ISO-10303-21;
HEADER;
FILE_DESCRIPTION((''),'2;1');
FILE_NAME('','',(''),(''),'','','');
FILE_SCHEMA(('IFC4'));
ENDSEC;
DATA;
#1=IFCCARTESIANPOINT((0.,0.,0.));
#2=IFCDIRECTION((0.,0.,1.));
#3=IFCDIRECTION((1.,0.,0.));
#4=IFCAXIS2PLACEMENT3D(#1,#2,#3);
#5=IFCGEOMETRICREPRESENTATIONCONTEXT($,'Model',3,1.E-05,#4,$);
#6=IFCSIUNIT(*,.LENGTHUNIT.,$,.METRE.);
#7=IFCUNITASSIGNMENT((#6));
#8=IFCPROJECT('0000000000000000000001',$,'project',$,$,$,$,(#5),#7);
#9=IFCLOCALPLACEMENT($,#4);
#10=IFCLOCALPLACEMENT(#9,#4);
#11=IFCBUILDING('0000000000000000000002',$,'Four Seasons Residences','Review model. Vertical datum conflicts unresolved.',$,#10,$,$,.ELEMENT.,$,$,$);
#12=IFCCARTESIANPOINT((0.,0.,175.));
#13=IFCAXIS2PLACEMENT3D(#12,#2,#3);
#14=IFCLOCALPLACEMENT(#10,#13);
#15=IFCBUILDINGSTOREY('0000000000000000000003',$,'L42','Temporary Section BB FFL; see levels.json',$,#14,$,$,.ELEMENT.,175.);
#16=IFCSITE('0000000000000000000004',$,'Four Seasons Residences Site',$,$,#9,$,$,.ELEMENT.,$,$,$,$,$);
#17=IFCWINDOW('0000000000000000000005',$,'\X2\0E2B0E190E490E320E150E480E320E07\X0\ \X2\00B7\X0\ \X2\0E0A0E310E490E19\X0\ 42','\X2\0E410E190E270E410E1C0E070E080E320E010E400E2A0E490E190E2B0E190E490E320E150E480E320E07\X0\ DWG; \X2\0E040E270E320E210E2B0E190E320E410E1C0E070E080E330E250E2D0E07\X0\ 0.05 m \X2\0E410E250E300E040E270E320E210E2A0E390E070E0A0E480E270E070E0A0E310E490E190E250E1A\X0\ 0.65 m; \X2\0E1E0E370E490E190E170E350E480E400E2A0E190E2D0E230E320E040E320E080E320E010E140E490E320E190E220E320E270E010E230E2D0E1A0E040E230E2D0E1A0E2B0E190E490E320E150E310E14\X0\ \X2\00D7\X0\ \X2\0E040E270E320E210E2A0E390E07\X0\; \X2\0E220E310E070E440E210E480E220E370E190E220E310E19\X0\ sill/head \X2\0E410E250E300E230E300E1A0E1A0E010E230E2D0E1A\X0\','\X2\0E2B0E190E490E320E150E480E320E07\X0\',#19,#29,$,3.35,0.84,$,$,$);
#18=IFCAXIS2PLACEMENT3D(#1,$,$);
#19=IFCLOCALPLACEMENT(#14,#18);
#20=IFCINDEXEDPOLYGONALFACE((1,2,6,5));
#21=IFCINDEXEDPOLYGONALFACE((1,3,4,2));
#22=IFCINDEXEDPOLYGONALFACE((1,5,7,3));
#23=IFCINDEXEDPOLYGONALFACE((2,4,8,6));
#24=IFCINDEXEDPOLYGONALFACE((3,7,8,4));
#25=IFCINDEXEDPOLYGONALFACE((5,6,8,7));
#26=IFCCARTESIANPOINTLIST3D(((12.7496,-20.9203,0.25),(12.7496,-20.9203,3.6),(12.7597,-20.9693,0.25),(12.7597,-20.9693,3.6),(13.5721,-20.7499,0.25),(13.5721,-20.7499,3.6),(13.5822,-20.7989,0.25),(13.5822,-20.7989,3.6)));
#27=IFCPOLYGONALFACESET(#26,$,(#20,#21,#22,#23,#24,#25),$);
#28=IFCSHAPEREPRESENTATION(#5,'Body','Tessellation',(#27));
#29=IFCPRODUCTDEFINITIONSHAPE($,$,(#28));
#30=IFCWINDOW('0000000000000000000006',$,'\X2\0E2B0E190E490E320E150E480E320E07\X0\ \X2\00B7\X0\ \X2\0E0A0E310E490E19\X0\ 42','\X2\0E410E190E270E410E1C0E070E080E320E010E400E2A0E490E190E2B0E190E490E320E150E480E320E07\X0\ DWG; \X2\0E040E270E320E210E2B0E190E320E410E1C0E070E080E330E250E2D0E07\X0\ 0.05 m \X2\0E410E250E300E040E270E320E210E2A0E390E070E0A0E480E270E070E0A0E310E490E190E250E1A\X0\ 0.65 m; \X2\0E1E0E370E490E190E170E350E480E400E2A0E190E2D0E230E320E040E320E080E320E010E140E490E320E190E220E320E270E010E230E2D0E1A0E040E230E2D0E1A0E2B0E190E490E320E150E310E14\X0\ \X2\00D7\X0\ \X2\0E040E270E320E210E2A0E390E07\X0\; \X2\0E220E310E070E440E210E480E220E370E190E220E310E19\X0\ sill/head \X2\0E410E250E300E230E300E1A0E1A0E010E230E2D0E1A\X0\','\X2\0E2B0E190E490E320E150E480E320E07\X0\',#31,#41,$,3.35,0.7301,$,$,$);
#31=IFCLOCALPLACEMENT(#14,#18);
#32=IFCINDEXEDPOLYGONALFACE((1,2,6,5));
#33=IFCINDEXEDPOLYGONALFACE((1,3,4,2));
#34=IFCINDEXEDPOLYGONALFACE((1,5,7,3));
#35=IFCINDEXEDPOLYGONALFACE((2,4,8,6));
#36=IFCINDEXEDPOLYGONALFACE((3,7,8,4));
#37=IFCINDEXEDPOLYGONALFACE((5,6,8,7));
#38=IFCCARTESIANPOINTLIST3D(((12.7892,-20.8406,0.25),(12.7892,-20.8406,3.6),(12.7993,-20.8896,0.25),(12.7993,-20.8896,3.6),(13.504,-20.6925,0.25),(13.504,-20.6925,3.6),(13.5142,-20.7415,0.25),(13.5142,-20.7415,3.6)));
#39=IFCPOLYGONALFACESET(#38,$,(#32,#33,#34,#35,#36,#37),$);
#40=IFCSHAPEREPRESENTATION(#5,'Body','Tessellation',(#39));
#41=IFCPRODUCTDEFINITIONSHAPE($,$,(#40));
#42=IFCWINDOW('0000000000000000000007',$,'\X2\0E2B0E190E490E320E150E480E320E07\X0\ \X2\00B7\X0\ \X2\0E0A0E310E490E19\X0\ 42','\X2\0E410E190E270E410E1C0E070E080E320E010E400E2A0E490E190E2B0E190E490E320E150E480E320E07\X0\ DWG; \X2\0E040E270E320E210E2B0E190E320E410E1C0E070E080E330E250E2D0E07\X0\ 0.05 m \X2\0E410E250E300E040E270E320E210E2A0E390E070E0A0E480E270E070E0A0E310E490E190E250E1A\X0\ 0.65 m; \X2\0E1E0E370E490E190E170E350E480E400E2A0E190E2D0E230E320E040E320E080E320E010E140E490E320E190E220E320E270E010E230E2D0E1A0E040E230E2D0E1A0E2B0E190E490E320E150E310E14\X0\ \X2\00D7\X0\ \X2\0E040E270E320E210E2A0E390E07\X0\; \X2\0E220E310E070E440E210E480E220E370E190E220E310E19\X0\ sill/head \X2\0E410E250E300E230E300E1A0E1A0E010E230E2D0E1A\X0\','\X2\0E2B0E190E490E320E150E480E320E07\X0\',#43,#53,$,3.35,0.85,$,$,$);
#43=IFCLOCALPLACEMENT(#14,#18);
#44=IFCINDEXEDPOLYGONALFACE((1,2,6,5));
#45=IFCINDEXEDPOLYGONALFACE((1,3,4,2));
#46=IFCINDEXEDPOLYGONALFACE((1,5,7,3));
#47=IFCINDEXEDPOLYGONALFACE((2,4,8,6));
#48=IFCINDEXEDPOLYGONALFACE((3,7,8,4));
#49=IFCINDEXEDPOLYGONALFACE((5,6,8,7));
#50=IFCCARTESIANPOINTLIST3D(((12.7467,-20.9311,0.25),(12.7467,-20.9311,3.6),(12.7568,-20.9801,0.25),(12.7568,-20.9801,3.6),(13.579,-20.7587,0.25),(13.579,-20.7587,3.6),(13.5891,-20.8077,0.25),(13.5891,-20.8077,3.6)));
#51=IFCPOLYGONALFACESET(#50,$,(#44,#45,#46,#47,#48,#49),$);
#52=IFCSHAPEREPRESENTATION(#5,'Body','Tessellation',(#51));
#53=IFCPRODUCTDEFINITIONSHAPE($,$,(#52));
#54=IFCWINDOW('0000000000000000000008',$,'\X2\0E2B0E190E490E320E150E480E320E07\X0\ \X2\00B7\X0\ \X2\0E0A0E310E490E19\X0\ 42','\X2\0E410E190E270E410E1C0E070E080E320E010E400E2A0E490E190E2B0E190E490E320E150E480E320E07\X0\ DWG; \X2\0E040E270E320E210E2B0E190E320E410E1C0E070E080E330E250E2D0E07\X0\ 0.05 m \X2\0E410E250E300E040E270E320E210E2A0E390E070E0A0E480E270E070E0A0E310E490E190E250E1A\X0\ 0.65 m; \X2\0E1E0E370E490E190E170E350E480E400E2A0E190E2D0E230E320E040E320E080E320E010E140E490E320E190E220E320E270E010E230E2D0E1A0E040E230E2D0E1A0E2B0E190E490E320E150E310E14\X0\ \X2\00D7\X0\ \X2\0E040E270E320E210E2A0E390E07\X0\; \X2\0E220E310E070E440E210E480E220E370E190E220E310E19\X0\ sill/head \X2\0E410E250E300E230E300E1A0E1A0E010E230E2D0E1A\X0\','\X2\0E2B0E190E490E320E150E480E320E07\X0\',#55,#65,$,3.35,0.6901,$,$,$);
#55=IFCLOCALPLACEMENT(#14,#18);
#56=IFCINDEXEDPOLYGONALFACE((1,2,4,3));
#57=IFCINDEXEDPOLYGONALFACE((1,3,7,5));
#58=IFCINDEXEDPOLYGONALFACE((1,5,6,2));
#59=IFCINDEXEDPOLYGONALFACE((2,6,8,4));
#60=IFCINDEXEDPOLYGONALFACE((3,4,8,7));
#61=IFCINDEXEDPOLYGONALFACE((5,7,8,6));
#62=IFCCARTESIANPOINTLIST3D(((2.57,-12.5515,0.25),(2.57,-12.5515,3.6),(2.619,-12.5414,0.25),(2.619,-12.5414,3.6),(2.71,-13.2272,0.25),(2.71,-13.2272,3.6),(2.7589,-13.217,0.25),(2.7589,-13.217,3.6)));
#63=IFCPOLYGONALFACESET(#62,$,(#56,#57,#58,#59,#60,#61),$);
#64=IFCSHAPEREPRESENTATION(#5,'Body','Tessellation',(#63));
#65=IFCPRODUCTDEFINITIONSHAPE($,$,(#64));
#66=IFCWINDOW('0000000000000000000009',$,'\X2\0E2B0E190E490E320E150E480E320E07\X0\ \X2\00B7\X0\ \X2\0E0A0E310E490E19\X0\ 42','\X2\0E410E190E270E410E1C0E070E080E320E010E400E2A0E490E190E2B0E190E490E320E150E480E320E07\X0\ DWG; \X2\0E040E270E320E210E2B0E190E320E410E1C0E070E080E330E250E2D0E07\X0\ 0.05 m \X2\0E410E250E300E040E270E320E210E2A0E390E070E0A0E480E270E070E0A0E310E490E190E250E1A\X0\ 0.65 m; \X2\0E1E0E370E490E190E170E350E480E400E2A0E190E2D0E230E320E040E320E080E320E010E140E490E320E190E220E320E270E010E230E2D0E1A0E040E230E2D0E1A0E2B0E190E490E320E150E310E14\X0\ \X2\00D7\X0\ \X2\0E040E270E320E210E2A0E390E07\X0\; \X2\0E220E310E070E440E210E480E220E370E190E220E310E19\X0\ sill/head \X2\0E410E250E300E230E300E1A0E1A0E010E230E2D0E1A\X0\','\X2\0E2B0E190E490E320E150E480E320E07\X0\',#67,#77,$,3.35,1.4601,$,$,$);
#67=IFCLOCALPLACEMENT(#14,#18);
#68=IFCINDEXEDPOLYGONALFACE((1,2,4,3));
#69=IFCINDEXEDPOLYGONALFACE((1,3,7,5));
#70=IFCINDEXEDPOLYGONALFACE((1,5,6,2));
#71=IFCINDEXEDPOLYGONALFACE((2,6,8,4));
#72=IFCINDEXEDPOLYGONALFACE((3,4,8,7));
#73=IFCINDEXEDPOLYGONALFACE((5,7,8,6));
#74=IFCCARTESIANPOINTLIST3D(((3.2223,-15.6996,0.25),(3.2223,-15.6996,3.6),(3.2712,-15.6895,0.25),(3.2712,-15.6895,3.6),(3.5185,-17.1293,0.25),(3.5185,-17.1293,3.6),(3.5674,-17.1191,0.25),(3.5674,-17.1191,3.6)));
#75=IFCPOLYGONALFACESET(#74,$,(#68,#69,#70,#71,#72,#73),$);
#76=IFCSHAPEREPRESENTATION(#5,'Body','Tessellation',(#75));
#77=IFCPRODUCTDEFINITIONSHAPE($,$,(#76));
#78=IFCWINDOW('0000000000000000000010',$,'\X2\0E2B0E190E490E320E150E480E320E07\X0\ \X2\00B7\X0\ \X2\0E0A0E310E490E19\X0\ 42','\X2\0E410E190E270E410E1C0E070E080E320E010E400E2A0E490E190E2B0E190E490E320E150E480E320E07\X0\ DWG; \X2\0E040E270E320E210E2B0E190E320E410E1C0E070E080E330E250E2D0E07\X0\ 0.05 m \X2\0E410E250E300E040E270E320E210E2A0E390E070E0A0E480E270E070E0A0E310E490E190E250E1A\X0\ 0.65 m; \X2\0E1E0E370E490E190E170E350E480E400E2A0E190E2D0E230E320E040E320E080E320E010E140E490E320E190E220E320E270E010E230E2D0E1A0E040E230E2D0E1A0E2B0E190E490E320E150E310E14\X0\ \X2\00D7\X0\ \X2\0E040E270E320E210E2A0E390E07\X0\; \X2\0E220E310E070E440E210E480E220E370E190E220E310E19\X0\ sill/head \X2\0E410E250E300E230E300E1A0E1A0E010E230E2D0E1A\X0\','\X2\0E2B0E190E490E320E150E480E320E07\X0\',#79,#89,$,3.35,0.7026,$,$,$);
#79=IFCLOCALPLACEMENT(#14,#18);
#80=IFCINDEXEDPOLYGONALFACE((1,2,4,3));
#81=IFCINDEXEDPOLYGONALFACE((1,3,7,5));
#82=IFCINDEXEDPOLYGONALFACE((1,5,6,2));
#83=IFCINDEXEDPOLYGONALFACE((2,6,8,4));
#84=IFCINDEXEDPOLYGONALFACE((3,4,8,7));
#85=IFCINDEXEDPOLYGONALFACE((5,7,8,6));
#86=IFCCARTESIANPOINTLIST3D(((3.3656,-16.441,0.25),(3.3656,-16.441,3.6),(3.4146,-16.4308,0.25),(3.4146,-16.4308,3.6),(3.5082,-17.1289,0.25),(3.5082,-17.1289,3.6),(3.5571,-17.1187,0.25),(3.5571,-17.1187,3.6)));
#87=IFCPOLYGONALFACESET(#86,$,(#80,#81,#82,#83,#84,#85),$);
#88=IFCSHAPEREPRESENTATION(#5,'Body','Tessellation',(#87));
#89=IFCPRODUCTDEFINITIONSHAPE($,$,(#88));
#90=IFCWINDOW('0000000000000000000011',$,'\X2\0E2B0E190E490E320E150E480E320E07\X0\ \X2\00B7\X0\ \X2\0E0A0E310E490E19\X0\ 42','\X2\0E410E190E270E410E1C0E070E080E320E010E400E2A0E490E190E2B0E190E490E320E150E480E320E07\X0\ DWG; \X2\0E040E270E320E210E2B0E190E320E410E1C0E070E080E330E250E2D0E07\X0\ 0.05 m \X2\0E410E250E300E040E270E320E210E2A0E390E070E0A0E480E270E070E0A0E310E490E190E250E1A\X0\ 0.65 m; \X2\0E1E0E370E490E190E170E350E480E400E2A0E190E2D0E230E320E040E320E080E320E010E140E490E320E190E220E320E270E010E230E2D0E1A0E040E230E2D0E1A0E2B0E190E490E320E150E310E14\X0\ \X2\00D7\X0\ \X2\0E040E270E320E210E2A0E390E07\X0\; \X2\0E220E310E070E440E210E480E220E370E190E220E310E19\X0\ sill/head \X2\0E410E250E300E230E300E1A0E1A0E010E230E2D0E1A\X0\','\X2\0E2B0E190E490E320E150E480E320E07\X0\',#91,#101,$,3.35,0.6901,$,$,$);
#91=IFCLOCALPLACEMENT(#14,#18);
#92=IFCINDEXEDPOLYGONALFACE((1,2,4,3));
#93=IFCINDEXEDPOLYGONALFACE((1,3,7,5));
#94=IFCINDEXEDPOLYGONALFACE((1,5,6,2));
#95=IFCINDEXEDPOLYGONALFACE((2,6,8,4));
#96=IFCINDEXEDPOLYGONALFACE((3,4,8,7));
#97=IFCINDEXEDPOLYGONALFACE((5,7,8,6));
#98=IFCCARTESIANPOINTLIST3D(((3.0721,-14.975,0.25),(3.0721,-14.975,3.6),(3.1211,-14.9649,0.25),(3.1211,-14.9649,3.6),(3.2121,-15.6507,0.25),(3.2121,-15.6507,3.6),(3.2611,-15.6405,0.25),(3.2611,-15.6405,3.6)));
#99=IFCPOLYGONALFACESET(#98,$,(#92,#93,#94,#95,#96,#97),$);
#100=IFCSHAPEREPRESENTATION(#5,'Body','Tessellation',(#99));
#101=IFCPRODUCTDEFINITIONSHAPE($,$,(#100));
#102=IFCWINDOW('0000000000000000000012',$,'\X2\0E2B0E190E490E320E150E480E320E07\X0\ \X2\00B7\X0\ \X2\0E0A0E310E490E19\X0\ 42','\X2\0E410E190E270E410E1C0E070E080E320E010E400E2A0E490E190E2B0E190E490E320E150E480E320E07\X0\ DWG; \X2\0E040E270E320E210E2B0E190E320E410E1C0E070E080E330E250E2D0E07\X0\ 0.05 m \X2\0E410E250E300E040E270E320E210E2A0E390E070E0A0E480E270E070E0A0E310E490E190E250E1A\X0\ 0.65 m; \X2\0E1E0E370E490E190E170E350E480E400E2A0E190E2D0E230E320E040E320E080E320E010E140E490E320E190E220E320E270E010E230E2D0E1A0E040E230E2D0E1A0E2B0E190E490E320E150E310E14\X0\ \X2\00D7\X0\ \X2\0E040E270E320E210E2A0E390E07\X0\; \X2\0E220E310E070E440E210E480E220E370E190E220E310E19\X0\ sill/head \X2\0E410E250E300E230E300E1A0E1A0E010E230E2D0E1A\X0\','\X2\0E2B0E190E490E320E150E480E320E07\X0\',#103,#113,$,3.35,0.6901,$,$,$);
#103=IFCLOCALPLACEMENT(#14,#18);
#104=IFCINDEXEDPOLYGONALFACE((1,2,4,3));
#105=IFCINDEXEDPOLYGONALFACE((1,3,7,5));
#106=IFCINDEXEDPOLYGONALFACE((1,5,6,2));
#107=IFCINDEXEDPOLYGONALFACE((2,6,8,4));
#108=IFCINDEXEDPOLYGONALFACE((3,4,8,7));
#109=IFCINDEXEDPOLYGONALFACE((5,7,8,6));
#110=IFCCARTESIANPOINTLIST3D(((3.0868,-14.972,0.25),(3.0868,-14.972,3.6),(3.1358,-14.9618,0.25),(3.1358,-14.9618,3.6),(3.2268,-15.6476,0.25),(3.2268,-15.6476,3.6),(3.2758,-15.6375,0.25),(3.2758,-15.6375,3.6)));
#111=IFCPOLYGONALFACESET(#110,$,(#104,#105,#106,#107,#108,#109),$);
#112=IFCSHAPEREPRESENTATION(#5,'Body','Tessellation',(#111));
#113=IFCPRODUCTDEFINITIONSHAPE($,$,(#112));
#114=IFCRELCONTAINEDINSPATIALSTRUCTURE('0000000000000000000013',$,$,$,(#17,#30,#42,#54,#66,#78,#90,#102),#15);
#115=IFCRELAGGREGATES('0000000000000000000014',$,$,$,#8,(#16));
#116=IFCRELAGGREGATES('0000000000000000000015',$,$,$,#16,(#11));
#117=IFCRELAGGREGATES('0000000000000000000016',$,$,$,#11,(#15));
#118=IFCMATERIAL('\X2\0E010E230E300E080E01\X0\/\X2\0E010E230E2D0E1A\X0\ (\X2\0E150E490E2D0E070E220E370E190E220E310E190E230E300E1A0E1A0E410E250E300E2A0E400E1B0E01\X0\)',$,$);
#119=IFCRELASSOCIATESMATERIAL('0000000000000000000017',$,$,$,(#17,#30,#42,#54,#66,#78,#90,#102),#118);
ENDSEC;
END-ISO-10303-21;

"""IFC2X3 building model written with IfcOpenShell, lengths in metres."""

from ifc_helpers import new_model, si_unit, frame, origin_with_axes, place, context, project, spatial, polyline, outline, extrude, material, element, save


model = new_model("IFC2X3")

# Units and contexts
model_context = context("Model", 3, precision=1e-05, world=origin_with_axes())
ifc_project = project(units=[si_unit("LENGTHUNIT", "METRE")], contexts=[model_context])

# Site, building, storey
site_placement = place(None, origin_with_axes())
site = spatial("IfcSite", under=ifc_project, at=site_placement, Name="Four Seasons Residences Site", CompositionType="ELEMENT")
building_placement = place(site_placement, origin_with_axes())
building = spatial("IfcBuilding", under=site, at=building_placement, Name="Four Seasons Residences", Description="Review model. Vertical datum conflicts unresolved.", CompositionType="ELEMENT")
storey_placement = place(building_placement, frame((0.0, 0.0, 175.0), z_axis=(0.0, 0.0, 1.0), x_axis=(1.0, 0.0, 0.0)))
storey = spatial("IfcBuildingStorey", under=building, at=storey_placement, Name="L42", Description="Temporary Section BB FFL; see levels.json", CompositionType="ELEMENT", Elevation=175.0)

# Windows
ifc_material = material(Name="กระจก/กรอบ (ต้องยืนยันระบบและสเปก)")
window_1_placement = place(storey_placement, origin_with_axes())
element("IfcWindow", 1, at=window_1_placement, inside=storey, material=ifc_material, Name="หน้าต่าง · ชั้น 42", Description="แนวแผงจากเส้นหน้าต่าง DWG; ความหนาแผงจำลอง 0.05 m และความสูงช่วงชั้นลบ 0.65 m; พื้นที่เสนอราคาจากด้านยาวกรอบครอบหน้าตัด × ความสูง; ยังไม่ยืนยัน sill/head และระบบกรอบ", ObjectType="หน้าต่าง", OverallHeight=3.35, OverallWidth=0.84, context=model_context, shape_type="SweptSolid", body=[
    extrude(outline(polyline([(13.5721, -20.7499), (13.5822, -20.7989), (12.7597, -20.9693), (12.7496, -20.9203), (13.5721, -20.7499)])), frame((0.0, 0.0, 0.25), z_axis=(0.0, 0.0, 1.0), x_axis=(1.0, 0.0, 0.0)), (0.0, 0.0, 1.0), 3.35),
])
window_2_placement = place(storey_placement, origin_with_axes())
element("IfcWindow", 2, at=window_2_placement, inside=storey, material=ifc_material, Name="หน้าต่าง · ชั้น 42", Description="แนวแผงจากเส้นหน้าต่าง DWG; ความหนาแผงจำลอง 0.05 m และความสูงช่วงชั้นลบ 0.65 m; พื้นที่เสนอราคาจากด้านยาวกรอบครอบหน้าตัด × ความสูง; ยังไม่ยืนยัน sill/head และระบบกรอบ", ObjectType="หน้าต่าง", OverallHeight=3.35, OverallWidth=0.7301, context=model_context, shape_type="SweptSolid", body=[
    extrude(outline(polyline([(13.504, -20.6925), (13.5142, -20.7415), (12.7993, -20.8896), (12.7892, -20.8406), (13.504, -20.6925)])), frame((0.0, 0.0, 0.25), z_axis=(0.0, 0.0, 1.0), x_axis=(1.0, 0.0, 0.0)), (0.0, 0.0, 1.0), 3.35),
])
window_3_placement = place(storey_placement, origin_with_axes())
element("IfcWindow", 3, at=window_3_placement, inside=storey, material=ifc_material, Name="หน้าต่าง · ชั้น 42", Description="แนวแผงจากเส้นหน้าต่าง DWG; ความหนาแผงจำลอง 0.05 m และความสูงช่วงชั้นลบ 0.65 m; พื้นที่เสนอราคาจากด้านยาวกรอบครอบหน้าตัด × ความสูง; ยังไม่ยืนยัน sill/head และระบบกรอบ", ObjectType="หน้าต่าง", OverallHeight=3.35, OverallWidth=0.85, context=model_context, shape_type="SweptSolid", body=[
    extrude(outline(polyline([(12.7568, -20.9801), (12.7467, -20.9311), (13.579, -20.7587), (13.5891, -20.8077), (12.7568, -20.9801)])), frame((0.0, 0.0, 0.25), z_axis=(0.0, 0.0, 1.0), x_axis=(1.0, 0.0, 0.0)), (0.0, 0.0, 1.0), 3.35),
])
window_4_placement = place(storey_placement, origin_with_axes())
element("IfcWindow", 4, at=window_4_placement, inside=storey, material=ifc_material, Name="หน้าต่าง · ชั้น 42", Description="แนวแผงจากเส้นหน้าต่าง DWG; ความหนาแผงจำลอง 0.05 m และความสูงช่วงชั้นลบ 0.65 m; พื้นที่เสนอราคาจากด้านยาวกรอบครอบหน้าตัด × ความสูง; ยังไม่ยืนยัน sill/head และระบบกรอบ", ObjectType="หน้าต่าง", OverallHeight=3.35, OverallWidth=0.6901, context=model_context, shape_type="SweptSolid", body=[
    extrude(outline(polyline([(2.7589, -13.217), (2.71, -13.2272), (2.57, -12.5515), (2.619, -12.5414), (2.7589, -13.217)])), frame((0.0, 0.0, 0.25), z_axis=(0.0, 0.0, 1.0), x_axis=(1.0, 0.0, 0.0)), (0.0, 0.0, 1.0), 3.35),
])
window_5_placement = place(storey_placement, origin_with_axes())
element("IfcWindow", 5, at=window_5_placement, inside=storey, material=ifc_material, Name="หน้าต่าง · ชั้น 42", Description="แนวแผงจากเส้นหน้าต่าง DWG; ความหนาแผงจำลอง 0.05 m และความสูงช่วงชั้นลบ 0.65 m; พื้นที่เสนอราคาจากด้านยาวกรอบครอบหน้าตัด × ความสูง; ยังไม่ยืนยัน sill/head และระบบกรอบ", ObjectType="หน้าต่าง", OverallHeight=3.35, OverallWidth=1.4601, context=model_context, shape_type="SweptSolid", body=[
    extrude(outline(polyline([(3.2223, -15.6996), (3.2712, -15.6895), (3.5674, -17.1191), (3.5185, -17.1293), (3.2223, -15.6996)])), frame((0.0, 0.0, 0.25), z_axis=(0.0, 0.0, 1.0), x_axis=(1.0, 0.0, 0.0)), (0.0, 0.0, 1.0), 3.35),
])
window_6_placement = place(storey_placement, origin_with_axes())
element("IfcWindow", 6, at=window_6_placement, inside=storey, material=ifc_material, Name="หน้าต่าง · ชั้น 42", Description="แนวแผงจากเส้นหน้าต่าง DWG; ความหนาแผงจำลอง 0.05 m และความสูงช่วงชั้นลบ 0.65 m; พื้นที่เสนอราคาจากด้านยาวกรอบครอบหน้าตัด × ความสูง; ยังไม่ยืนยัน sill/head และระบบกรอบ", ObjectType="หน้าต่าง", OverallHeight=3.35, OverallWidth=0.7026, context=model_context, shape_type="SweptSolid", body=[
    extrude(outline(polyline([(3.3656, -16.441), (3.4146, -16.4308), (3.5571, -17.1187), (3.5082, -17.1289), (3.3656, -16.441)])), frame((0.0, 0.0, 0.25), z_axis=(0.0, 0.0, 1.0), x_axis=(1.0, 0.0, 0.0)), (0.0, 0.0, 1.0), 3.35),
])
window_7_placement = place(storey_placement, origin_with_axes())
element("IfcWindow", 7, at=window_7_placement, inside=storey, material=ifc_material, Name="หน้าต่าง · ชั้น 42", Description="แนวแผงจากเส้นหน้าต่าง DWG; ความหนาแผงจำลอง 0.05 m และความสูงช่วงชั้นลบ 0.65 m; พื้นที่เสนอราคาจากด้านยาวกรอบครอบหน้าตัด × ความสูง; ยังไม่ยืนยัน sill/head และระบบกรอบ", ObjectType="หน้าต่าง", OverallHeight=3.35, OverallWidth=0.6901, context=model_context, shape_type="SweptSolid", body=[
    extrude(outline(polyline([(3.0721, -14.975), (3.1211, -14.9649), (3.2611, -15.6405), (3.2121, -15.6507), (3.0721, -14.975)])), frame((0.0, 0.0, 0.25), z_axis=(0.0, 0.0, 1.0), x_axis=(1.0, 0.0, 0.0)), (0.0, 0.0, 1.0), 3.35),
])
window_8_placement = place(storey_placement, origin_with_axes())
element("IfcWindow", 8, at=window_8_placement, inside=storey, material=ifc_material, Name="หน้าต่าง · ชั้น 42", Description="แนวแผงจากเส้นหน้าต่าง DWG; ความหนาแผงจำลอง 0.05 m และความสูงช่วงชั้นลบ 0.65 m; พื้นที่เสนอราคาจากด้านยาวกรอบครอบหน้าตัด × ความสูง; ยังไม่ยืนยัน sill/head และระบบกรอบ", ObjectType="หน้าต่าง", OverallHeight=3.35, OverallWidth=0.6901, context=model_context, shape_type="SweptSolid", body=[
    extrude(outline(polyline([(3.0868, -14.972), (3.1358, -14.9618), (3.2758, -15.6375), (3.2268, -15.6476), (3.0868, -14.972)])), frame((0.0, 0.0, 0.25), z_axis=(0.0, 0.0, 1.0), x_axis=(1.0, 0.0, 0.0)), (0.0, 0.0, 1.0), 3.35),
])

save(model, "model.ifc")
